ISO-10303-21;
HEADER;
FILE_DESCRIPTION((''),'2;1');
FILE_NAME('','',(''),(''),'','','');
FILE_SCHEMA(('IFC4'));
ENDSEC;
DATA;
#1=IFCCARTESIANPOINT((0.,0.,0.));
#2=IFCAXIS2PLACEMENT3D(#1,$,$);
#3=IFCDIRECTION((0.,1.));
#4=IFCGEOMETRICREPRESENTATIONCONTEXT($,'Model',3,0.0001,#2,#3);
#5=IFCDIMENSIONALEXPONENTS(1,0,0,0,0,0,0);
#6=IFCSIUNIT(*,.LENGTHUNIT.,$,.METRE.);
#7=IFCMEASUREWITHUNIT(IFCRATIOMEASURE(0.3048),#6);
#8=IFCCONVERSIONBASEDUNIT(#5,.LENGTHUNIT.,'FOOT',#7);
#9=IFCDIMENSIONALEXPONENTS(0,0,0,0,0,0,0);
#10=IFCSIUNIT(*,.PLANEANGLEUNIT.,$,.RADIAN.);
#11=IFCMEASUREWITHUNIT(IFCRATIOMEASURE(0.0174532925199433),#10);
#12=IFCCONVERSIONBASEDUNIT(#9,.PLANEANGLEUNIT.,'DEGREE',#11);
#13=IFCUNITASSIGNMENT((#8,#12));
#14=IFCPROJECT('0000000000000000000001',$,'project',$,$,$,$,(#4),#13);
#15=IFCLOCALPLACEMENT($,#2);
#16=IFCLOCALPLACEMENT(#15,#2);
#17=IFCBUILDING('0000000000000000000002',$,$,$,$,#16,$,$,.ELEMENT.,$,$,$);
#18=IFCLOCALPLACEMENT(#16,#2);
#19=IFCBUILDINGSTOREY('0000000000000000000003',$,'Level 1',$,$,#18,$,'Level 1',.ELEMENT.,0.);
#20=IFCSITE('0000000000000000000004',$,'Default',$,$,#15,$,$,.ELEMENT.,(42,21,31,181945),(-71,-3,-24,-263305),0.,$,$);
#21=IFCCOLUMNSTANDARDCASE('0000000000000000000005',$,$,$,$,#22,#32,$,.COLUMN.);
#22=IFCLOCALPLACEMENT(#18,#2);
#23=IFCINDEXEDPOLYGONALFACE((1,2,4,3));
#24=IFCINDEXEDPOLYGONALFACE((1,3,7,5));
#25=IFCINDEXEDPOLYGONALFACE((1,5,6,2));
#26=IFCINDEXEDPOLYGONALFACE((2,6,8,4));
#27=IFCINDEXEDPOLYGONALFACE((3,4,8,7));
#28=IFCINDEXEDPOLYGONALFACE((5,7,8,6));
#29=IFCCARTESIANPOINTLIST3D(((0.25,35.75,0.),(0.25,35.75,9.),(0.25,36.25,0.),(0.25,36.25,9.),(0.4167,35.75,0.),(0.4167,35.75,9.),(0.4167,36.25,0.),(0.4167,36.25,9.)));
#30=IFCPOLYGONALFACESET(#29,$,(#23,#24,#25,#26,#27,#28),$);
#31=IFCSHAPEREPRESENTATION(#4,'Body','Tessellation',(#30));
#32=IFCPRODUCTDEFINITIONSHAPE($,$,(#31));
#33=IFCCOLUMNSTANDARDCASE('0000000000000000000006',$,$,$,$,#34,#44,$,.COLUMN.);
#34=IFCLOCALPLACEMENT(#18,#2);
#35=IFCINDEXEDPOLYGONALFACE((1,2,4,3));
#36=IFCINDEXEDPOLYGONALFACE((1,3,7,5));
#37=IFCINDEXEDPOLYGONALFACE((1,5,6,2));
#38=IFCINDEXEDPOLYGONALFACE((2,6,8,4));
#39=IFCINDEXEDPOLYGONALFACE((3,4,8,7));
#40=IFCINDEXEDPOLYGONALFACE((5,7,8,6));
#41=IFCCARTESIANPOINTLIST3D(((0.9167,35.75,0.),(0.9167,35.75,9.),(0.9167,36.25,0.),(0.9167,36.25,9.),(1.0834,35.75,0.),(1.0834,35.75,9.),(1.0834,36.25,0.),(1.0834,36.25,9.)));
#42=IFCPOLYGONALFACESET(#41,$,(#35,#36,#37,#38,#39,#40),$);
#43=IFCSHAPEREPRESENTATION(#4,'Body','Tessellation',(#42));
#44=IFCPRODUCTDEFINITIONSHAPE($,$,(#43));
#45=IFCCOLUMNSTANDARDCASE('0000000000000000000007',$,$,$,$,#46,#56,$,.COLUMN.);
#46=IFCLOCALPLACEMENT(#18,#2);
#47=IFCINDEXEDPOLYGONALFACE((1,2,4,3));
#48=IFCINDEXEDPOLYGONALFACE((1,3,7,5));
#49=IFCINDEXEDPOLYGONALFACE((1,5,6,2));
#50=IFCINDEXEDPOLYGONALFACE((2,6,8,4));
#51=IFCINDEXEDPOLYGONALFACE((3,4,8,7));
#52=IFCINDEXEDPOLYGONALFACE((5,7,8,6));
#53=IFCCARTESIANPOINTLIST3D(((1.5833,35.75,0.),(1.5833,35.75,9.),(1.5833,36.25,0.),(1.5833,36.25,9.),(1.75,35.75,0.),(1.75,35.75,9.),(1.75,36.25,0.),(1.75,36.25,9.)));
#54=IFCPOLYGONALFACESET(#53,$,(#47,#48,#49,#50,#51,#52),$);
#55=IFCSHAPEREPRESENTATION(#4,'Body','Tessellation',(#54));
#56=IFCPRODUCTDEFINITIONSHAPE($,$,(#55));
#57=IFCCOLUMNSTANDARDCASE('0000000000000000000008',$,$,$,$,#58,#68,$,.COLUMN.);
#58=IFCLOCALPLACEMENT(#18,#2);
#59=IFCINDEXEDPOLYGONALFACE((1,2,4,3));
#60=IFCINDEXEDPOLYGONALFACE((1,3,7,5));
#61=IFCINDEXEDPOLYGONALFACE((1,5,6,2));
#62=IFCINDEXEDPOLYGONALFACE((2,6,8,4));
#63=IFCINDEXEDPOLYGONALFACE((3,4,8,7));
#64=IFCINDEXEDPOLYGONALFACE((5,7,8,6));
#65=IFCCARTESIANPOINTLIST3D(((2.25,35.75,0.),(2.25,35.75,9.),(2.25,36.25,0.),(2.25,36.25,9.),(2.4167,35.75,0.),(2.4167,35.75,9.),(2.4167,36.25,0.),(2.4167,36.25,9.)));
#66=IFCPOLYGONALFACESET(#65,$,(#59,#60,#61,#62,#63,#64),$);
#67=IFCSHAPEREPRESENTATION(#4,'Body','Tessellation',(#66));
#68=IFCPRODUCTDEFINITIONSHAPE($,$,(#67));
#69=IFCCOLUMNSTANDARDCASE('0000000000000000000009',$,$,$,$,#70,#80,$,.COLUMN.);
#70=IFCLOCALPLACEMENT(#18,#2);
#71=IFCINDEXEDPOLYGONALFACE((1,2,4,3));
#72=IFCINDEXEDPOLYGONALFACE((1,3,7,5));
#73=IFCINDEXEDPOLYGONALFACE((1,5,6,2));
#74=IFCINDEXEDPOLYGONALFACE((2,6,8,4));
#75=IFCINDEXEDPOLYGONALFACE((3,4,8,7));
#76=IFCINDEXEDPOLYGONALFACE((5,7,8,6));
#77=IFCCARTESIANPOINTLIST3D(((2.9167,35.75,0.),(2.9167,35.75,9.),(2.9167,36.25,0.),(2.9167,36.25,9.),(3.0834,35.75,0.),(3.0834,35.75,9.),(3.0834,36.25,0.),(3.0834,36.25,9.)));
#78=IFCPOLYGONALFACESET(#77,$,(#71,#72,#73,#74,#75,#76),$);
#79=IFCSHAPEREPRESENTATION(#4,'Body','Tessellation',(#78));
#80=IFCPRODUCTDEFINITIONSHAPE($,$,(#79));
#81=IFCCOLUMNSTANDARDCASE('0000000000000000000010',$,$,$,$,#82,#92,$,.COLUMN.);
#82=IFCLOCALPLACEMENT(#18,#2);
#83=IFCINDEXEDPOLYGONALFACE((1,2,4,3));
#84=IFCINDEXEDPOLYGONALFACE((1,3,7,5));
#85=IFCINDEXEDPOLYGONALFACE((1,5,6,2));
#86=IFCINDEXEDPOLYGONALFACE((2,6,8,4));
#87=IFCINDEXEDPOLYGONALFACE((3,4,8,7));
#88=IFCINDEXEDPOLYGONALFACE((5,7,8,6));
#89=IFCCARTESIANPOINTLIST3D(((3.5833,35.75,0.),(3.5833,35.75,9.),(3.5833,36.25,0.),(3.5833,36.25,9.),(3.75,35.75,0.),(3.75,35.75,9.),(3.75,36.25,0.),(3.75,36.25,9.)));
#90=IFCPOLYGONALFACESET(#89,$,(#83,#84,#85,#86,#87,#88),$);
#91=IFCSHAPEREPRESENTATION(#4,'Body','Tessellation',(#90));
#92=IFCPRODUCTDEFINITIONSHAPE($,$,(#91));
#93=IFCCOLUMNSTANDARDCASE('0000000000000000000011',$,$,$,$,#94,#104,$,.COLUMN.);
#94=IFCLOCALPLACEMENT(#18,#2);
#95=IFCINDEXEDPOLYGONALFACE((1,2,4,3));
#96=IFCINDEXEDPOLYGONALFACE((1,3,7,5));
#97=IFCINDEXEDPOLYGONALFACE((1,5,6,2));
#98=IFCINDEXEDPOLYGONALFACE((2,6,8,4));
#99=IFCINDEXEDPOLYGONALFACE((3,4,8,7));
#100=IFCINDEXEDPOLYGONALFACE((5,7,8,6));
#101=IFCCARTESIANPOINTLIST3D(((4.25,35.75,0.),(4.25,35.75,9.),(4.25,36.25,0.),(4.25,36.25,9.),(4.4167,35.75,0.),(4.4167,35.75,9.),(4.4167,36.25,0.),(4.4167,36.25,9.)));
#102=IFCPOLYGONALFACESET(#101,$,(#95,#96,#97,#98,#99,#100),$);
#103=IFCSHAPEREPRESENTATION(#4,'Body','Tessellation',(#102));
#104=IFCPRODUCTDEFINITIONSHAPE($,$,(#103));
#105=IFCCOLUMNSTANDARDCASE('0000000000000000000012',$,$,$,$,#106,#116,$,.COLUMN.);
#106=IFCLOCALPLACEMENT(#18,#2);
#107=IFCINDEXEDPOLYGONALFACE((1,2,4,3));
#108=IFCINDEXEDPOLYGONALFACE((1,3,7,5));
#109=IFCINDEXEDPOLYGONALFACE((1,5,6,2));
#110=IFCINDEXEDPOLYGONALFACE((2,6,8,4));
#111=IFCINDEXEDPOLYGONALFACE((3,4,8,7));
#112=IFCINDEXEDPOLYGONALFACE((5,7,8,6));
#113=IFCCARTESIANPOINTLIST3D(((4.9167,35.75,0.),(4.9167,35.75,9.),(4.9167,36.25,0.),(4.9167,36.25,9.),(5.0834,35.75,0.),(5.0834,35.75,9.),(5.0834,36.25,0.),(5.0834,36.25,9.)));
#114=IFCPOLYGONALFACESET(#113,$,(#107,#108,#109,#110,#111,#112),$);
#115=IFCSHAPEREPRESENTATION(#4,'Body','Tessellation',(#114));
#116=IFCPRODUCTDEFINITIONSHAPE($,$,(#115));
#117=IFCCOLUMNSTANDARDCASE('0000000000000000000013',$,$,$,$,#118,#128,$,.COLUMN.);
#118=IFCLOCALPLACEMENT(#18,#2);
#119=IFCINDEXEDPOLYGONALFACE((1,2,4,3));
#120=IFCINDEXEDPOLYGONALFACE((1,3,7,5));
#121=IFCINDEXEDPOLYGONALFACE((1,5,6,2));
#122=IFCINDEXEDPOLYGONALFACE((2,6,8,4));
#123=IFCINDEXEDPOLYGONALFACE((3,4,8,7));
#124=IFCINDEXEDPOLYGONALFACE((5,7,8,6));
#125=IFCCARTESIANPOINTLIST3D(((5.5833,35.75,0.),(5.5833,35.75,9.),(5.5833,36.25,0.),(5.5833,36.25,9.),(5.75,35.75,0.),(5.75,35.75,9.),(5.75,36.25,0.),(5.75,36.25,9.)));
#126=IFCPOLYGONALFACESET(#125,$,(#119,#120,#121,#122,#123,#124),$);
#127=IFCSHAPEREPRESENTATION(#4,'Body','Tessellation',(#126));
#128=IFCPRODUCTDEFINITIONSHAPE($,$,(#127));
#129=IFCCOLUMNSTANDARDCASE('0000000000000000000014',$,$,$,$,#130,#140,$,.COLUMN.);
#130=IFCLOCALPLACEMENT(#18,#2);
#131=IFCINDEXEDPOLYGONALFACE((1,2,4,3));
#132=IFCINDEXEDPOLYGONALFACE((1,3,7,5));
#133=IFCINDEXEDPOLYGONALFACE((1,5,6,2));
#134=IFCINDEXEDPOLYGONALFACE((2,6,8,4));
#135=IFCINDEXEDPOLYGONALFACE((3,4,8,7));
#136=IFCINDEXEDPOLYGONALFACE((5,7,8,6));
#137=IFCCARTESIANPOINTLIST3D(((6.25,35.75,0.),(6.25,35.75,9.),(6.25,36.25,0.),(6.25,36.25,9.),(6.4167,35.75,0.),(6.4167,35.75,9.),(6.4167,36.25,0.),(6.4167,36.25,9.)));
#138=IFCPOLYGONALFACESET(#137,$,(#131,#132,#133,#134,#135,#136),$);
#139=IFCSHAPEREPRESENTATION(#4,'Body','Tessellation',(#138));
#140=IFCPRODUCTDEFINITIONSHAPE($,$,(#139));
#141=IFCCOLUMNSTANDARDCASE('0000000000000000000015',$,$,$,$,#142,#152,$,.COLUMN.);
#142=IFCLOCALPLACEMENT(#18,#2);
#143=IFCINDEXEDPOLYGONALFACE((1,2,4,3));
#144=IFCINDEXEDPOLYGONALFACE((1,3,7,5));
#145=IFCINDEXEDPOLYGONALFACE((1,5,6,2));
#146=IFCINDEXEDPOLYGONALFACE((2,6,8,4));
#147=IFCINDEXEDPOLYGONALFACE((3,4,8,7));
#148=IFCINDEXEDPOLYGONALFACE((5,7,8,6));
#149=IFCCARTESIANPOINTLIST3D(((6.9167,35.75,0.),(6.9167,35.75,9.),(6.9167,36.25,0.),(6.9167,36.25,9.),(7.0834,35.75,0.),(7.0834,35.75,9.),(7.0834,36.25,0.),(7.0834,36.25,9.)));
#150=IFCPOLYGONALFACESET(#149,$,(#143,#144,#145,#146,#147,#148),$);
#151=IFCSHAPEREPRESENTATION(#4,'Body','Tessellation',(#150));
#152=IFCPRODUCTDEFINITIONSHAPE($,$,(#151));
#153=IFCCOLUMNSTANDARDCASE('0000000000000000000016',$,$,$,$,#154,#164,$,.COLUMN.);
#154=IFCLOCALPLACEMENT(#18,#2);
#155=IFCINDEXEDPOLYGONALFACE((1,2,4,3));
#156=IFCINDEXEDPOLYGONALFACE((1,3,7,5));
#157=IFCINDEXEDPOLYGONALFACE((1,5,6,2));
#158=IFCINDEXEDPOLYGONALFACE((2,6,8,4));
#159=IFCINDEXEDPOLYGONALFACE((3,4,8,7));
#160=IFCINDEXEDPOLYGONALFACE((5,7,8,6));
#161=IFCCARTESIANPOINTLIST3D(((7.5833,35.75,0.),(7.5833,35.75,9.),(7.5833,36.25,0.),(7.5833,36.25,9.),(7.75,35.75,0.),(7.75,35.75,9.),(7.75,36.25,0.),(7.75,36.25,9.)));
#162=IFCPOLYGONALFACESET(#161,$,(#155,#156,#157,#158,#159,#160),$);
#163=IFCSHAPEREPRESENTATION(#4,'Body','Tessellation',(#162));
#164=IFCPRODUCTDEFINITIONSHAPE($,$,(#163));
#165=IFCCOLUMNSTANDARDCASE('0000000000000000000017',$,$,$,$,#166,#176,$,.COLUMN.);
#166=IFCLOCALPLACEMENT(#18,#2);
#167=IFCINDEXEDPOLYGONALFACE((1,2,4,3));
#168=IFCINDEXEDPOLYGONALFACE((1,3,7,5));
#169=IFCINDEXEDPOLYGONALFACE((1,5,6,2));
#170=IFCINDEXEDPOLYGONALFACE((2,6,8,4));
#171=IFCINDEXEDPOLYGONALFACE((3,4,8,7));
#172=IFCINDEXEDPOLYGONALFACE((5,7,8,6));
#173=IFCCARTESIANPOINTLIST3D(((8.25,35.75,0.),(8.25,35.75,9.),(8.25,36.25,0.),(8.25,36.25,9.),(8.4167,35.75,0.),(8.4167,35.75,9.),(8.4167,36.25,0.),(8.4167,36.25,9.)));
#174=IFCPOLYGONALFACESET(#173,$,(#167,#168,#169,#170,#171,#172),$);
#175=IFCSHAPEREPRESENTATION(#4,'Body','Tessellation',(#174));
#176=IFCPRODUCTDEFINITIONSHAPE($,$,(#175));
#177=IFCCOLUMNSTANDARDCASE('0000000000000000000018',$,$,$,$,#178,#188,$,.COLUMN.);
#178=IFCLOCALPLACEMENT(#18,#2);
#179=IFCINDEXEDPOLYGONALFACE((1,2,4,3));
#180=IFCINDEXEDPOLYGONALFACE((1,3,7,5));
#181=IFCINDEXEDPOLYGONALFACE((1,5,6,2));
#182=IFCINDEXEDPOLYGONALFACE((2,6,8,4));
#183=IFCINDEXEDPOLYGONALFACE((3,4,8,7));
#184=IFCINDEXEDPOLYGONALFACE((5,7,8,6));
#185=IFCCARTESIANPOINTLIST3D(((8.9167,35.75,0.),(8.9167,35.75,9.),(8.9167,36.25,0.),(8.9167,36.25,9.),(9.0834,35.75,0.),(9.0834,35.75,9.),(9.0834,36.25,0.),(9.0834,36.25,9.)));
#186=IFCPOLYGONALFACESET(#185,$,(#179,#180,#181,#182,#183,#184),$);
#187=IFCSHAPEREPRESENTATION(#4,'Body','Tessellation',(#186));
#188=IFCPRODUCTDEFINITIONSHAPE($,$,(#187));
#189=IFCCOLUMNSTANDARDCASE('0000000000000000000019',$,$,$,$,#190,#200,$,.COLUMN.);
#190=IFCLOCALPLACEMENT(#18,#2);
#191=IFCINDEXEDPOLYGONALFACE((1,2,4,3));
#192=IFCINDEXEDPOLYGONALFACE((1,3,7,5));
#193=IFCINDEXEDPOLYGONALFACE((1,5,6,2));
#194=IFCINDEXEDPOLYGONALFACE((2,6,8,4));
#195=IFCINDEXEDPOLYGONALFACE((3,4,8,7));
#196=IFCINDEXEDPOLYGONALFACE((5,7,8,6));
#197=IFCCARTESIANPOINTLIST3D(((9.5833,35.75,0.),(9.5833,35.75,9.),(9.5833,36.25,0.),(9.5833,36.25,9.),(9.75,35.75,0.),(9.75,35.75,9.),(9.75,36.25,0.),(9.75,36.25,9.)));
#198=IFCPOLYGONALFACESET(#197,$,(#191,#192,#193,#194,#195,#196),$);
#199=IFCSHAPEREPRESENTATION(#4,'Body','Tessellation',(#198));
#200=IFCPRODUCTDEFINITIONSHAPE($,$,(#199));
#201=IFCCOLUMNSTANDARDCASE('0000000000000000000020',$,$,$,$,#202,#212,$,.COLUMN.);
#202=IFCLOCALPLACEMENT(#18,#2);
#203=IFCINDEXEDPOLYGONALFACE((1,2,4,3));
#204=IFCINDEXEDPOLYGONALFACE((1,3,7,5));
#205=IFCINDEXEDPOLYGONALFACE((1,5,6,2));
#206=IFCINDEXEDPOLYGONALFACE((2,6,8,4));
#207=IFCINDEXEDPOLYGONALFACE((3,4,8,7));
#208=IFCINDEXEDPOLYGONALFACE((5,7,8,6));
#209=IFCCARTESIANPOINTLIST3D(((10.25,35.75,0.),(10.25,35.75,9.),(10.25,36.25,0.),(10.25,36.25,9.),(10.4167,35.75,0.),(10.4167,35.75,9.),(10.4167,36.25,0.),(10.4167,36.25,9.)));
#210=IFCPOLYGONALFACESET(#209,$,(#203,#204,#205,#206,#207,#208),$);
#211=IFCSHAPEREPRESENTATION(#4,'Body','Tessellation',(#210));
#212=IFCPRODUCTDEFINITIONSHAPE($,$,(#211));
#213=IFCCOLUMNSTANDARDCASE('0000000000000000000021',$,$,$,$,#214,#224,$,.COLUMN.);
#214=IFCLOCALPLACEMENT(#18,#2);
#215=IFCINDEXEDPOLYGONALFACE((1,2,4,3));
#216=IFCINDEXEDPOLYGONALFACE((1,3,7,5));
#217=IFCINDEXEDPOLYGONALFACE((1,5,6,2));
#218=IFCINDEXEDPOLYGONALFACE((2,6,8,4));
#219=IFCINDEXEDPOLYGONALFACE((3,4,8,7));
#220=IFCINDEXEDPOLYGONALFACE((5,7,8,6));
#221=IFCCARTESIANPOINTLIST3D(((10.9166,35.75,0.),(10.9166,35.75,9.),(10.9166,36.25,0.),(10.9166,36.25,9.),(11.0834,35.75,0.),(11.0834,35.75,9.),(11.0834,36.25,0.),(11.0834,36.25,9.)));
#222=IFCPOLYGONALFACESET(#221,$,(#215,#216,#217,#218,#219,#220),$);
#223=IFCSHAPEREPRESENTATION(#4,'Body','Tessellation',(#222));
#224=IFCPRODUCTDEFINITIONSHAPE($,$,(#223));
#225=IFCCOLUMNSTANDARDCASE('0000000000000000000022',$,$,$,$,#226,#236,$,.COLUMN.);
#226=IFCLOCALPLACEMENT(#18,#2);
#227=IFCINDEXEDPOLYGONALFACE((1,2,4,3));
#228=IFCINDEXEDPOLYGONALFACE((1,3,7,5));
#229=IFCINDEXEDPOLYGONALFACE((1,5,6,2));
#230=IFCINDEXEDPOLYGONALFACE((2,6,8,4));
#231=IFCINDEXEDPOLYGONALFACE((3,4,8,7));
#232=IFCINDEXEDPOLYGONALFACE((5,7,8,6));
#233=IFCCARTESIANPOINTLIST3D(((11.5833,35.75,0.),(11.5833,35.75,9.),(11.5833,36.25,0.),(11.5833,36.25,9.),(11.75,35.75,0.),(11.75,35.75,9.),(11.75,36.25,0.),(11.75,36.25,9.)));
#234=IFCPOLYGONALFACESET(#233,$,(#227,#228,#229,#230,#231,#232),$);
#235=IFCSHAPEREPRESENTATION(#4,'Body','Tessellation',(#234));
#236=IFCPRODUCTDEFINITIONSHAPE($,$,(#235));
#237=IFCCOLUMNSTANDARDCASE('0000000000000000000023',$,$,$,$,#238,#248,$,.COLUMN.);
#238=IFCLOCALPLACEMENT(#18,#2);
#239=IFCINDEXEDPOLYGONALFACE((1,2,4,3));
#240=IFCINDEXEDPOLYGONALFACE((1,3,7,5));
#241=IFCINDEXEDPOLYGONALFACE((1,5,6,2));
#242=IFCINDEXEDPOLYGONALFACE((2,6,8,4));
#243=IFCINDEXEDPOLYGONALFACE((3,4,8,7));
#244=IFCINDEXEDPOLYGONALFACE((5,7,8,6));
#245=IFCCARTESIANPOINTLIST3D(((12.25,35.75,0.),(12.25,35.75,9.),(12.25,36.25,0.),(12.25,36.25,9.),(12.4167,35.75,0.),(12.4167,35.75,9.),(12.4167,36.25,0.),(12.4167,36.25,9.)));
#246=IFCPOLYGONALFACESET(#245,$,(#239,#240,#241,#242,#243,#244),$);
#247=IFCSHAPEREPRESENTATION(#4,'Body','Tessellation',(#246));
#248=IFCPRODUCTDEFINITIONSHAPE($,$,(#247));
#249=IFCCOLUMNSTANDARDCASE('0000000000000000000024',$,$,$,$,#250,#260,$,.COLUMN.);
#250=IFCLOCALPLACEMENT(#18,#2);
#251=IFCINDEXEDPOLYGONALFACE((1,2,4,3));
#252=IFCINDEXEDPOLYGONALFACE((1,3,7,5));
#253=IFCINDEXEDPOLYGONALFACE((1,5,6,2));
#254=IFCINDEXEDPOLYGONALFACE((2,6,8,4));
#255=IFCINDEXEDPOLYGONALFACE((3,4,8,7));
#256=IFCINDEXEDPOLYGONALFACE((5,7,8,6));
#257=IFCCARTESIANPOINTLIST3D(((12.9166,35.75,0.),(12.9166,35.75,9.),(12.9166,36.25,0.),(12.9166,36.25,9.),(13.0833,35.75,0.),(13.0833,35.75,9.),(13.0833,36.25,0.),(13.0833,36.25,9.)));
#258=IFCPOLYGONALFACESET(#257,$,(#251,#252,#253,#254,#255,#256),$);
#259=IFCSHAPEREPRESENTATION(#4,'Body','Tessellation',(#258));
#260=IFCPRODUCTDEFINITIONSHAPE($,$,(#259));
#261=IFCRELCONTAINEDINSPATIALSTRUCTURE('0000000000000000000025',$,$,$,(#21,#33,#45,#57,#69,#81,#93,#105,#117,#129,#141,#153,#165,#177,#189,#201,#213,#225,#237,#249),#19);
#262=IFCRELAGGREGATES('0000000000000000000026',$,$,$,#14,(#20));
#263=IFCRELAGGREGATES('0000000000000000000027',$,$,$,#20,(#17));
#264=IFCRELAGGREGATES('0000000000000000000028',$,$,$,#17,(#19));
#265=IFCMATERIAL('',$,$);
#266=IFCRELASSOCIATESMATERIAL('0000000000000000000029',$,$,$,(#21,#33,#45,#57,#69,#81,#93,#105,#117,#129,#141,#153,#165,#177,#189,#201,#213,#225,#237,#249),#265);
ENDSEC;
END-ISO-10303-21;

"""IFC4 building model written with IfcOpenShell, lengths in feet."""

from ifc_helpers import new_model, entity, si_unit, converted_unit, direction, frame, origin, place, context, project, spatial, rectangle, extrude, material, element, save


model = new_model("IFC4")

# Units and contexts
model_context = context("Model", 3, precision=0.0001, world=origin(), true_north=direction((0.0, 1.0)))
ifc_project = project(units=[converted_unit("LENGTHUNIT", "FOOT", entity("IfcRatioMeasure", 0.3048), si_unit("LENGTHUNIT", "METRE"), dimensions=[1, 0, 0, 0, 0, 0, 0]), converted_unit("PLANEANGLEUNIT", "DEGREE", entity("IfcRatioMeasure", 0.0174532925199433), si_unit("PLANEANGLEUNIT", "RADIAN"), dimensions=[0, 0, 0, 0, 0, 0, 0])], contexts=[model_context])

# Site, building, storey
site_placement = place(None, origin())
site = spatial("IfcSite", under=ifc_project, at=site_placement, Name="Default", CompositionType="ELEMENT", RefLatitude=(42, 21, 31, 181945), RefLongitude=(-71, -3, -24, -263305), RefElevation=0.0)
building_placement = place(site_placement, origin())
building = spatial("IfcBuilding", under=site, at=building_placement, CompositionType="ELEMENT")
storey_placement = place(building_placement, origin())
storey = spatial("IfcBuildingStorey", under=building, at=storey_placement, Name="Level 1", LongName="Level 1", CompositionType="ELEMENT", Elevation=0.0)

# Columns
ifc_material_1 = material(Name="")
placement = place(storey_placement, frame((0.25, 36.0, 0.0)))
for number, where, z_axis, x_axis in (
    (1, (0.0833, 0.0, 0.0), (0.0, 0.0, 1.0), (1.0, 0.0, 0.0)),
    (2, (0.75, 0.0, 0.0), (0.0, 0.0, 1.0), (1.0, 0.0, 0.0)),
    (3, (1.4167, 0.0, 0.0), (0.0, 0.0, 1.0), (1.0, 0.0, 0.0)),
    (4, (2.0833, 0.0, 0.0), (0.0, 0.0, 1.0), (1.0, 0.0, 0.0)),
    (5, (2.75, 0.0, 0.0), (0.0, 0.0, 1.0), (1.0, 0.0, 0.0)),
    (6, (3.4167, 0.0, 0.0), (0.0, 0.0, 1.0), (1.0, 0.0, 0.0)),
    (7, (4.0833, 0.0, 0.0), (0.0, 0.0, 1.0), (1.0, 0.0, 0.0)),
    (8, (4.75, 0.0, 0.0), (0.0, 0.0, 1.0), (1.0, 0.0, 0.0)),
    (9, (5.4167, 0.0, 0.0), (0.0, 0.0, 1.0), (1.0, 0.0, 0.0)),
    (10, (6.0833, 0.0, 0.0), (0.0, 0.0, 1.0), (1.0, 0.0, 0.0)),
    (11, (6.75, 0.0, 0.0), (0.0, 0.0, 1.0), (1.0, 0.0, 0.0)),
    (12, (7.4167, 0.0, 0.0), (0.0, 0.0, 1.0), (1.0, 0.0, 0.0)),
    (13, (8.0833, 0.0, 0.0), (0.0, 0.0, 1.0), (1.0, 0.0, 0.0)),
    (14, (8.75, 0.0, 0.0), (0.0, 0.0, 1.0), (1.0, 0.0, 0.0)),
    (15, (9.4167, 0.0, 0.0), (0.0, 0.0, 1.0), (1.0, 0.0, 0.0)),
    (16, (10.0833, 0.0, 0.0), (0.0, 0.0, 1.0), (1.0, 0.0, 0.0)),
    (17, (10.75, 0.0, 0.0), (0.0, 0.0, 1.0), (1.0, 0.0, 0.0)),
    (18, (11.4167, 0.0, 0.0), (0.0, 0.0, 1.0), (1.0, 0.0, 0.0)),
    (19, (12.0833, 0.0, 0.0), (0.0, 0.0, 1.0), (1.0, 0.0, 0.0)),
    (20, (12.75, 0.0, 0.0), (0.0, 0.0, 1.0), (1.0, 0.0, 0.0)),
):
    element("IfcColumnStandardCase", number, at=place(placement, frame(where, z_axis=z_axis, x_axis=x_axis)), inside=storey, material=ifc_material_1, PredefinedType="COLUMN", context=model_context, shape_type="SweptSolid", body=[
        extrude(rectangle(XDim=0.1667, YDim=0.5), origin(), (0.0, 0.0, 1.0), 9.0),
    ])

save(model, "model.ifc")
